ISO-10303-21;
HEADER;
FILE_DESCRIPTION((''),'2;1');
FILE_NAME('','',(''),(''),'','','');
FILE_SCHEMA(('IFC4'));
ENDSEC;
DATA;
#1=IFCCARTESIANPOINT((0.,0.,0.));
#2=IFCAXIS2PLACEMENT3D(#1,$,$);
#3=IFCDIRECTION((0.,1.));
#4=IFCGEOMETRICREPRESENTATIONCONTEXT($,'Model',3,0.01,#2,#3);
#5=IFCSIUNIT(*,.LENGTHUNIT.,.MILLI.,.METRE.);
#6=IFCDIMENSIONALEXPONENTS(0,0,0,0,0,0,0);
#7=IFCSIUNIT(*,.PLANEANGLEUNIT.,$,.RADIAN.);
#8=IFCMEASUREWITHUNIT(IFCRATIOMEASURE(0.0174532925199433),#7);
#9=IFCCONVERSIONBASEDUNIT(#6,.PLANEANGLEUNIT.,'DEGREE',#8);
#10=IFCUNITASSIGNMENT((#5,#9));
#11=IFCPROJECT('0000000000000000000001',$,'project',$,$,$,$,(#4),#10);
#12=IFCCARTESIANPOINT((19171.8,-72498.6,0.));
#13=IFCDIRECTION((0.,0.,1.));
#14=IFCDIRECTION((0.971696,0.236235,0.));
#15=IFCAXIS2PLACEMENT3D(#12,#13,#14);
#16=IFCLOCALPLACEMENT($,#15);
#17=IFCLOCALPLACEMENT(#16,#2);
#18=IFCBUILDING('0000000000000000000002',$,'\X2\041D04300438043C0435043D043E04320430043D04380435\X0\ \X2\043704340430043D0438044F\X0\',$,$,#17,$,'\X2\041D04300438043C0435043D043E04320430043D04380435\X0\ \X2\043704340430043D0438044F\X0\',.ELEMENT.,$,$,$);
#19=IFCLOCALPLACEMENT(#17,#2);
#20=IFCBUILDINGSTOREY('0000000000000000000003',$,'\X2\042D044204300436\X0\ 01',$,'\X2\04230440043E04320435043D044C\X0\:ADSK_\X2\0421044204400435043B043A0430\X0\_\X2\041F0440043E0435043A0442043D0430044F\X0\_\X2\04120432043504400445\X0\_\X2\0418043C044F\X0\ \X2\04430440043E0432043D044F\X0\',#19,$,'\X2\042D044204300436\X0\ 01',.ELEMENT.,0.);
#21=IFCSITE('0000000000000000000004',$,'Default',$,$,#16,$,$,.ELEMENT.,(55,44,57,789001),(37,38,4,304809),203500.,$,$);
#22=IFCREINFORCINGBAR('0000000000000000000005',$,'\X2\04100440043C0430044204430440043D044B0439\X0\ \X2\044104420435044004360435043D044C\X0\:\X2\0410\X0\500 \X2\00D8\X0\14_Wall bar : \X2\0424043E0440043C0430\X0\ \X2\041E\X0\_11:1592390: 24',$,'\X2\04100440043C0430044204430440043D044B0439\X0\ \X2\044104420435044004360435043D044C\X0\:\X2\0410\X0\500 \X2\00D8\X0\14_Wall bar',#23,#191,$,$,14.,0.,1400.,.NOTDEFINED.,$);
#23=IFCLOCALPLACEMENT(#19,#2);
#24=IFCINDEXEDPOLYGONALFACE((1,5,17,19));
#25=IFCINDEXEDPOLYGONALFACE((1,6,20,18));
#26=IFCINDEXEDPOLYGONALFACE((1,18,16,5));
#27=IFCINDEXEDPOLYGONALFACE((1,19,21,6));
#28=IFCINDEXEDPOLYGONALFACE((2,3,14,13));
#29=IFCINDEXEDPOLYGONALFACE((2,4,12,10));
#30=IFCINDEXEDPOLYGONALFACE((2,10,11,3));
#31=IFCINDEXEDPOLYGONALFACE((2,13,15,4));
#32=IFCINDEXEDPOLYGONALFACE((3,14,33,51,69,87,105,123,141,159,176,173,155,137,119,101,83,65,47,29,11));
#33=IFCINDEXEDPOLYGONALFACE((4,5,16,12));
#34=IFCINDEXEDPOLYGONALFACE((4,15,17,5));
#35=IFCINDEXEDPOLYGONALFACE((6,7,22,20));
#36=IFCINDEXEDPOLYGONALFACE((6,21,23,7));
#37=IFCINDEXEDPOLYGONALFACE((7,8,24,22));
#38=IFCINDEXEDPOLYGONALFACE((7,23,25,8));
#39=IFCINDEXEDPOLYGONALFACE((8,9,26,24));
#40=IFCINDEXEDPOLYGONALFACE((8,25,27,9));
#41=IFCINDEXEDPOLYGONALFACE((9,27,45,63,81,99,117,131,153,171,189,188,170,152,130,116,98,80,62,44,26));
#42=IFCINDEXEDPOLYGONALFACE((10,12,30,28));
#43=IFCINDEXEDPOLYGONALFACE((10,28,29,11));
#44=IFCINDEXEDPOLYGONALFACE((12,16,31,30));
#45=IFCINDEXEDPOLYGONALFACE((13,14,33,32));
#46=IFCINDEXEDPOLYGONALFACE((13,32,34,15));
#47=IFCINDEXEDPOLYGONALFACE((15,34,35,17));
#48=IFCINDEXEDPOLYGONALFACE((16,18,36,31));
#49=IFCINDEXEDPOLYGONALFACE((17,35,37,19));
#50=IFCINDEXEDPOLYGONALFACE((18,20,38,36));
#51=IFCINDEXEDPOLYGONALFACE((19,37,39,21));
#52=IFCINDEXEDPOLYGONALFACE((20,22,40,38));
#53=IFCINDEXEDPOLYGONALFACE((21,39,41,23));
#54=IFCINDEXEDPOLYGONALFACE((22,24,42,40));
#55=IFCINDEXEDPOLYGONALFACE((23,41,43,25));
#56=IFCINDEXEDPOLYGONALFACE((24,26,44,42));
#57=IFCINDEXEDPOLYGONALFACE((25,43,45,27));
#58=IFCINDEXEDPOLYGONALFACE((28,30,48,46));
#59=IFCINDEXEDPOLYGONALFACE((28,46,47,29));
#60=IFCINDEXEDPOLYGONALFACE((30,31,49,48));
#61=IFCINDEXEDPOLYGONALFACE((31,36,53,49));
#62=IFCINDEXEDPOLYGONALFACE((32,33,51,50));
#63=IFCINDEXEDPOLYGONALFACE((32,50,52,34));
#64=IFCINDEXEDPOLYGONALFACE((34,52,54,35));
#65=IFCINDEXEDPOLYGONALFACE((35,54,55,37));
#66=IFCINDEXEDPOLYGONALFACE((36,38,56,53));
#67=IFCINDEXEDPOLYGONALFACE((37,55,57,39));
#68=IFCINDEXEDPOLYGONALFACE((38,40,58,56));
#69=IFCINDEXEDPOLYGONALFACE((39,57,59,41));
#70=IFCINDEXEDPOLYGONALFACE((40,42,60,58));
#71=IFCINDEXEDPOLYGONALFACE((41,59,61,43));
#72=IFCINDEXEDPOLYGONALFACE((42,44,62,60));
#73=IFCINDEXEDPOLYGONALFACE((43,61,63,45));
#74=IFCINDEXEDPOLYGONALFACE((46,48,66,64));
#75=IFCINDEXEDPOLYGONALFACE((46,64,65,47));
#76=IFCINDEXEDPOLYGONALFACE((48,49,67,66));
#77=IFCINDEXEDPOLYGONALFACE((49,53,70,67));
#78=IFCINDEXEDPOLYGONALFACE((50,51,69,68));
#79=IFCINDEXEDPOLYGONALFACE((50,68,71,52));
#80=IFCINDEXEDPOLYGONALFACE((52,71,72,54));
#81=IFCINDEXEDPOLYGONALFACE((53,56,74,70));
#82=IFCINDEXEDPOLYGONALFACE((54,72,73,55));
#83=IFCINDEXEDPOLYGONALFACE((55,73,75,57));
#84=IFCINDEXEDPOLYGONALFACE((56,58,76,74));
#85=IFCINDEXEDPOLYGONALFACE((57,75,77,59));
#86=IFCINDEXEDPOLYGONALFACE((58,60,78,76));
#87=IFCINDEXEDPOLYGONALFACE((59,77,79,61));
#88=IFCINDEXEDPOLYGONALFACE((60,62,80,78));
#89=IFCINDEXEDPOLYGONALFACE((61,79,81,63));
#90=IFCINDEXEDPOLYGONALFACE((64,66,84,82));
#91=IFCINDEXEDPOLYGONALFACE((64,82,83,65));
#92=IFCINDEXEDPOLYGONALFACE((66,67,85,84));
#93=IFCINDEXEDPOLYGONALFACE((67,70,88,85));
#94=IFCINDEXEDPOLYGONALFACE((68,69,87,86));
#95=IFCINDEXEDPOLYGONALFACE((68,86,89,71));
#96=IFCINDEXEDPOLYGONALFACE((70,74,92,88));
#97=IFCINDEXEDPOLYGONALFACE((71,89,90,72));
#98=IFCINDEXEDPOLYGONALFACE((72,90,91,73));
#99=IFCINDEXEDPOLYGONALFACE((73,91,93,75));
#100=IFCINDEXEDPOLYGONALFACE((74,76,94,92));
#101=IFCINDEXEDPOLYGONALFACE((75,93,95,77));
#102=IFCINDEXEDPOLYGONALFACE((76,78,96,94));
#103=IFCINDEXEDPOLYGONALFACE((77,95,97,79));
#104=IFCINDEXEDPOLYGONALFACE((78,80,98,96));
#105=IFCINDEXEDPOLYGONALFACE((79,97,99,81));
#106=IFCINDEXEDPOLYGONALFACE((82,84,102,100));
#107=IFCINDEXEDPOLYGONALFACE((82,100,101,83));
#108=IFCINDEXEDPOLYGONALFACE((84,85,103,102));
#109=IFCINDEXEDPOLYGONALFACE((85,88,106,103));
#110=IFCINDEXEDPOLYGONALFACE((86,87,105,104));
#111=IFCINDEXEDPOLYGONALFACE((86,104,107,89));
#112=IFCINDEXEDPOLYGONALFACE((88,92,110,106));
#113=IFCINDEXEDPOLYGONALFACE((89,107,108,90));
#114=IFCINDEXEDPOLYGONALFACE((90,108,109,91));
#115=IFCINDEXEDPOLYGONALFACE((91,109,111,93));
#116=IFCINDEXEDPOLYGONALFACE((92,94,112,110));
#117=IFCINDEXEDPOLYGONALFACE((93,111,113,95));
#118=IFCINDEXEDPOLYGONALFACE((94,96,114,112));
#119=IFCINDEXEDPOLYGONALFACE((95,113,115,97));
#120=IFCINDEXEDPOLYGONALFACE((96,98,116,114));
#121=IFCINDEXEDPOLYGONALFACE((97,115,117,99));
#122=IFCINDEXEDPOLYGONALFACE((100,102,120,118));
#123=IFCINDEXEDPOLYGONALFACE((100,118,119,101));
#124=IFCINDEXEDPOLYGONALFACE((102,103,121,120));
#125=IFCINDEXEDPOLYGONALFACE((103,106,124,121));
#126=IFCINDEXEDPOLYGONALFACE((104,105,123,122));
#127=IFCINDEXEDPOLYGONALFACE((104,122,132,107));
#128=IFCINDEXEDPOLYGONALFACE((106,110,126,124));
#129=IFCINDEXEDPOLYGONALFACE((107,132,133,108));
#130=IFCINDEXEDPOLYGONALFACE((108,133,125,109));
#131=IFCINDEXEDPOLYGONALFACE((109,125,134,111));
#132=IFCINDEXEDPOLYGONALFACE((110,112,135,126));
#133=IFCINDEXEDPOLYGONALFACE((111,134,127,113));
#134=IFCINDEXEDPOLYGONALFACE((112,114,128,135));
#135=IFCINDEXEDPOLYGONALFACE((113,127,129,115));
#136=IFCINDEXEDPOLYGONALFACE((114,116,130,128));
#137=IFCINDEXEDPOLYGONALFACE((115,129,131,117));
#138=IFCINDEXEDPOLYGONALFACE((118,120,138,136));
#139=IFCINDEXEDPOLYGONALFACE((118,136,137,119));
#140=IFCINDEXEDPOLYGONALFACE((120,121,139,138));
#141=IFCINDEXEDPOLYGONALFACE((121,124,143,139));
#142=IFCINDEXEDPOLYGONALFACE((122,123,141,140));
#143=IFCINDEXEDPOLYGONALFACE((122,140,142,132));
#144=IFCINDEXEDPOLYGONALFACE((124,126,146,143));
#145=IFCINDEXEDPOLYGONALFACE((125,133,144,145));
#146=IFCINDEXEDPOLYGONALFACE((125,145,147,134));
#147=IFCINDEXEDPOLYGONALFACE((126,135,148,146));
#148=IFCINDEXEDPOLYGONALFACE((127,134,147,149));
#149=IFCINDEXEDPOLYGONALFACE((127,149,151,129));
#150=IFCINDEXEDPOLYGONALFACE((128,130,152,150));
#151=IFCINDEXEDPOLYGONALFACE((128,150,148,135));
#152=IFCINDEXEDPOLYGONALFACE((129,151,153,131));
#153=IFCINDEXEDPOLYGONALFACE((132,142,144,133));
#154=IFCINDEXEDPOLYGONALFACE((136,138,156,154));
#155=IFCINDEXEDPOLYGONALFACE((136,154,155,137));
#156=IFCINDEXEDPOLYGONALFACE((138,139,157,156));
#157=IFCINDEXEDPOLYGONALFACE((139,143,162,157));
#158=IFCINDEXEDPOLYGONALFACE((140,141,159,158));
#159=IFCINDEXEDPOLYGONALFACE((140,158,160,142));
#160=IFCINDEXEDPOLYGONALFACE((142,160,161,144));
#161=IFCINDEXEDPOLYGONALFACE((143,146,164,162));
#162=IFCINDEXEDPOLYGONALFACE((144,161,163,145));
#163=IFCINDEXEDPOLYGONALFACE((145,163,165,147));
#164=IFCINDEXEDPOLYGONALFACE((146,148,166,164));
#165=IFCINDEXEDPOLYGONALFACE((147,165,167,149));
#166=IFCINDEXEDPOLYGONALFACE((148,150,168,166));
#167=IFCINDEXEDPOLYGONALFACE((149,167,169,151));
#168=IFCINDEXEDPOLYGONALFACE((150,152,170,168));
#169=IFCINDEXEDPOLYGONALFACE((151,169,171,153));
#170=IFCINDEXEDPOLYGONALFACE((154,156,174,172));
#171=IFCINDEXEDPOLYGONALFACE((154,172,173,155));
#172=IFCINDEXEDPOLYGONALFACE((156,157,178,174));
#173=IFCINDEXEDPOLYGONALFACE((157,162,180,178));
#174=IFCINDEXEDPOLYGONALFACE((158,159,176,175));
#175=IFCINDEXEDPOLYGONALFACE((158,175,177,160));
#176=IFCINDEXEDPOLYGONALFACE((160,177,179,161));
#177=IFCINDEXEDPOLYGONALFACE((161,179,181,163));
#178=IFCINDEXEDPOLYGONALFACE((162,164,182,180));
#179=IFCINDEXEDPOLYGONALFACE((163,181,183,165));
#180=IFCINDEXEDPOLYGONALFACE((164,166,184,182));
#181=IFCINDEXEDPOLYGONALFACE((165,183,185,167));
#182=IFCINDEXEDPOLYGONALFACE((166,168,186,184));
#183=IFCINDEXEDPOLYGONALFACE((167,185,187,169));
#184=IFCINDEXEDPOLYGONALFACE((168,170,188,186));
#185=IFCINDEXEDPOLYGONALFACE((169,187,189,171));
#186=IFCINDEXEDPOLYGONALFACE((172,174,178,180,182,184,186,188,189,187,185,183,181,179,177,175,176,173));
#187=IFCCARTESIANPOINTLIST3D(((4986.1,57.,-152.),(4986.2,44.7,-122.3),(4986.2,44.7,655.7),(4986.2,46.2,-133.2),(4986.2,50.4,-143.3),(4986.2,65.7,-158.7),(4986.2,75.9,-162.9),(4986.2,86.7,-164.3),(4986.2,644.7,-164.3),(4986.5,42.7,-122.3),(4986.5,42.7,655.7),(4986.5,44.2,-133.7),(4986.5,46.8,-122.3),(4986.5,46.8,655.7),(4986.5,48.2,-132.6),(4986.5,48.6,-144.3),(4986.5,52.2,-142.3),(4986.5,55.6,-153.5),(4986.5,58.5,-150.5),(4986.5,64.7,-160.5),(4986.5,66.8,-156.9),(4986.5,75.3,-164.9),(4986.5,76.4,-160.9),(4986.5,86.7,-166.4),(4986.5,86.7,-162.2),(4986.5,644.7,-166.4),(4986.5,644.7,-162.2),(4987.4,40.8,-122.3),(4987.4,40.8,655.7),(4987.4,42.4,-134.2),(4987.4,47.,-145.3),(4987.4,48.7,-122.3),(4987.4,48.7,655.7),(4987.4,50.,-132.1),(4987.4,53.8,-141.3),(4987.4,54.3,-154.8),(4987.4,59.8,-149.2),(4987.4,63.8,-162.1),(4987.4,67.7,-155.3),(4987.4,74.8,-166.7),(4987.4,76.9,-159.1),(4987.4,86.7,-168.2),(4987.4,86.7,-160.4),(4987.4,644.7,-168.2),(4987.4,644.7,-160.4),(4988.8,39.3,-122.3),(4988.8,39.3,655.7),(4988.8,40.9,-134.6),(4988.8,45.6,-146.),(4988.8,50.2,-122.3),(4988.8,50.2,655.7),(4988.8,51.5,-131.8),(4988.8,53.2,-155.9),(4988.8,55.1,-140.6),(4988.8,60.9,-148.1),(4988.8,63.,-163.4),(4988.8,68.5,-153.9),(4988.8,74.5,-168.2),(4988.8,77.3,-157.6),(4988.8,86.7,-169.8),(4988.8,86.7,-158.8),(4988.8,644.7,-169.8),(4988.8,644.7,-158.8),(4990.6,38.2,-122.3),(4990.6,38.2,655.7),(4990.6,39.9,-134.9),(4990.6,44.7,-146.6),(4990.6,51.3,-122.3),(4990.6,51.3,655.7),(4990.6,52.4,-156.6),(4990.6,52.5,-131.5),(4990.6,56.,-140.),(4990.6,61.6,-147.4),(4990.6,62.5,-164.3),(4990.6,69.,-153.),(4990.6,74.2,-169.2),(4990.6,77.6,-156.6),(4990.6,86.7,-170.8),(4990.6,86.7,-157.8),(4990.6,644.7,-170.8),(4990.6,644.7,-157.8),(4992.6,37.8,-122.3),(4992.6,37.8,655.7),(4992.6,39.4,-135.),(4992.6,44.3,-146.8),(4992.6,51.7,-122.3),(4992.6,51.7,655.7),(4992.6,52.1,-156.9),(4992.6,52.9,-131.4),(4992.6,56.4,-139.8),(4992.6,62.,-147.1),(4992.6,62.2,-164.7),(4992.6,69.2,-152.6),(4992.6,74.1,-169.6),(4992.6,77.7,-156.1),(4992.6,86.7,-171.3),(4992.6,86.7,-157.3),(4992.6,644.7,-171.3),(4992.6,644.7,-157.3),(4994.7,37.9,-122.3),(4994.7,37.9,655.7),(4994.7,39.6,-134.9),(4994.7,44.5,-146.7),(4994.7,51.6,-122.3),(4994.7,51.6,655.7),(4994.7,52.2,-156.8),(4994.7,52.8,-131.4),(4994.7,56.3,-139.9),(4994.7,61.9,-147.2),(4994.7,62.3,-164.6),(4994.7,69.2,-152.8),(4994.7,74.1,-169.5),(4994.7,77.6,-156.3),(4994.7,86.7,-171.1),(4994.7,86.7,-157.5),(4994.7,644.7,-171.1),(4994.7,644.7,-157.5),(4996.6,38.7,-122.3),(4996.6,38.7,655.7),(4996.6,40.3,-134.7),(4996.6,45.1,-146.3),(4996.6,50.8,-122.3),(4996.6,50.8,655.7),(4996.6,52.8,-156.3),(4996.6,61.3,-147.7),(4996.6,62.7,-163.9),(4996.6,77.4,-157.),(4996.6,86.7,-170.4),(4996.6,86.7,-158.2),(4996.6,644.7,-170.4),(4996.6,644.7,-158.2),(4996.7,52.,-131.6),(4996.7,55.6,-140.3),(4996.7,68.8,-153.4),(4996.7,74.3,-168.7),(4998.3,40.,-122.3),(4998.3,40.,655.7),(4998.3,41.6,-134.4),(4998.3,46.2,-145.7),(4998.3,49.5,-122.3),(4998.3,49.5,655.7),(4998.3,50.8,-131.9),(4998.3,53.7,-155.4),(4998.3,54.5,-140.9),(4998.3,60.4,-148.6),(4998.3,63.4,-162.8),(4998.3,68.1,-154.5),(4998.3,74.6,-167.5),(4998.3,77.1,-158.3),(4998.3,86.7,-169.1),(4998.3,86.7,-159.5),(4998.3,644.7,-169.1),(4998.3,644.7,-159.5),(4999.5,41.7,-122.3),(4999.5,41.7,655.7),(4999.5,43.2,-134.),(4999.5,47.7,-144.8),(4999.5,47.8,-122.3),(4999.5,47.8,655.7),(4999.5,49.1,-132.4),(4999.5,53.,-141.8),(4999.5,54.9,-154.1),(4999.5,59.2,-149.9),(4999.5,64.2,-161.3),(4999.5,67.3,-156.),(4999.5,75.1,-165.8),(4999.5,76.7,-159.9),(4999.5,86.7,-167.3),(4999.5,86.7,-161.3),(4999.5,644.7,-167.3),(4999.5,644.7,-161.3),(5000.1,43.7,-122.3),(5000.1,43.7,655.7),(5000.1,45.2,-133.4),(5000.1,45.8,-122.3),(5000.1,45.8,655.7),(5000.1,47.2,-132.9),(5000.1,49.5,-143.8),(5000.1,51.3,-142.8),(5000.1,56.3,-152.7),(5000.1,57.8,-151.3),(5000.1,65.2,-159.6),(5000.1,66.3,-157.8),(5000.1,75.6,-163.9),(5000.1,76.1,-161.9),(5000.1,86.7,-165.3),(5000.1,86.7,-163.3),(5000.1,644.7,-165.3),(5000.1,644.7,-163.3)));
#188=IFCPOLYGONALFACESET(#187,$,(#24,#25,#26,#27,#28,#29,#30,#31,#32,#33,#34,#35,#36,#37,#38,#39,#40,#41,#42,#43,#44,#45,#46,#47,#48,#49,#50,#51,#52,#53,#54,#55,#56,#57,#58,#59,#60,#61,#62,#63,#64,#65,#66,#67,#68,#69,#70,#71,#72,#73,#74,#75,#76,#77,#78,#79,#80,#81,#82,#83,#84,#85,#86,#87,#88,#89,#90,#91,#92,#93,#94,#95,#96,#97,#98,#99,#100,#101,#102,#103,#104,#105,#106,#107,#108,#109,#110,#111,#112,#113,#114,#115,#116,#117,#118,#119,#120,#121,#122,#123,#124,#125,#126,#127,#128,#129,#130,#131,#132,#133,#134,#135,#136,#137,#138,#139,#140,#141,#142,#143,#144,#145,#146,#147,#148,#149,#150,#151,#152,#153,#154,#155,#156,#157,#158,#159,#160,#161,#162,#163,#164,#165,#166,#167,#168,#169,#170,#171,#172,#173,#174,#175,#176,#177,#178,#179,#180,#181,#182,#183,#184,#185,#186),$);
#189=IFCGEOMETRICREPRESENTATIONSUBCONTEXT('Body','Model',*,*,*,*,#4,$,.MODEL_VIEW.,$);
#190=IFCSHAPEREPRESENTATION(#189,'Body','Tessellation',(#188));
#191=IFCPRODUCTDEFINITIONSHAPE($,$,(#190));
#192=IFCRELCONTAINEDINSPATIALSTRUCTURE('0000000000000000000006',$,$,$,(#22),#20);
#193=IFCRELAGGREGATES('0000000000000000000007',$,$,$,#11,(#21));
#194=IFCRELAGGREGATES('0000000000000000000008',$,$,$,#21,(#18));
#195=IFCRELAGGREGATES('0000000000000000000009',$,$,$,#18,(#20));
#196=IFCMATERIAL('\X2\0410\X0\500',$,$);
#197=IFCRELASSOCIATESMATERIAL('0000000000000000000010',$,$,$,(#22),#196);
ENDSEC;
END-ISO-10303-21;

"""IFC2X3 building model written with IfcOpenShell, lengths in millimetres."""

from ifc_helpers import new_model, entity, si_unit, converted_unit, direction, frame, origin, place, context, subcontext, project, spatial, material, element, save


model = new_model("IFC2X3")

# Units and contexts
model_context = context("Model", 3, precision=0.01, world=origin(), true_north=direction((0.0, 1.0)))
body_context = subcontext(model_context, "Body", "Model", "MODEL_VIEW")
ifc_project = project(units=[si_unit("LENGTHUNIT", "METRE", prefix="MILLI"), converted_unit("PLANEANGLEUNIT", "DEGREE", entity("IfcRatioMeasure", 0.0174532925199433), si_unit("PLANEANGLEUNIT", "RADIAN"), dimensions=[0, 0, 0, 0, 0, 0, 0])], contexts=[model_context])

# Site, building, storey
site_placement = place(None, frame((19171.8, -72498.6, 0.0), z_axis=(0.0, 0.0, 1.0), x_axis=(0.971696, 0.236235, 0.0)))
site = spatial("IfcSite", under=ifc_project, at=site_placement, Name="Default", CompositionType="ELEMENT", RefLatitude=(55, 44, 57, 789001), RefLongitude=(37, 38, 4, 304809), RefElevation=203500.0)
building_placement = place(site_placement, origin())
building = spatial("IfcBuilding", under=site, at=building_placement, Name="Наименование здания", LongName="Наименование здания", CompositionType="ELEMENT")
storey_placement = place(building_placement, origin())
storey = spatial("IfcBuildingStorey", under=building, at=storey_placement, Name="Этаж 01", ObjectType="Уровень:ADSK_Стрелка_Проектная_Вверх_Имя уровня", LongName="Этаж 01", CompositionType="ELEMENT", Elevation=0.0)

# Reinforcing bar
ifc_material = material(Name="А500")
placement = place(storey_placement, origin())
element("IfcReinforcingBar", 1, at=placement, inside=storey, material=ifc_material, Name="Арматурный стержень:А500 Ø14_Wall bar : Форма О_11:1592390: 24", ObjectType="Арматурный стержень:А500 Ø14_Wall bar", BarLength=1400.0, BarRole="NOTDEFINED", CrossSectionArea=0.0, NominalDiameter=14.0, context=body_context, shape_type="AdvancedSweptSolid", body=[
    entity("IfcSweptDiskSolid", entity("IfcCompositeCurve", [entity("IfcCompositeCurveSegment", "CONTINUOUS", True, entity("IfcPolyline", [entity("IfcCartesianPoint", [4993.1, 44.7, 655.7]), entity("IfcCartesianPoint", [4993.1, 44.7, -122.3])])), entity("IfcCompositeCurveSegment", "CONTINUOUS", True, entity("IfcTrimmedCurve", entity("IfcCircle", entity("IfcAxis2Placement3D", entity("IfcCartesianPoint", [4993.1, 86.7, -122.3]), entity("IfcDirection", [1.0, 0.0, 0.0]), entity("IfcDirection", [0.0, 0.0, -1.0])), 42.0), [entity("IfcParameterValue", 270.0)], [entity("IfcParameterValue", 360.0)], True, "PARAMETER")), entity("IfcCompositeCurveSegment", "CONTINUOUS", True, entity("IfcPolyline", [entity("IfcCartesianPoint", [4993.1, 86.7, -164.3]), entity("IfcCartesianPoint", [4993.1, 644.7, -164.3])]))], False), 7.0, None, 0.0, 92.0),
])

save(model, "model.ifc")
